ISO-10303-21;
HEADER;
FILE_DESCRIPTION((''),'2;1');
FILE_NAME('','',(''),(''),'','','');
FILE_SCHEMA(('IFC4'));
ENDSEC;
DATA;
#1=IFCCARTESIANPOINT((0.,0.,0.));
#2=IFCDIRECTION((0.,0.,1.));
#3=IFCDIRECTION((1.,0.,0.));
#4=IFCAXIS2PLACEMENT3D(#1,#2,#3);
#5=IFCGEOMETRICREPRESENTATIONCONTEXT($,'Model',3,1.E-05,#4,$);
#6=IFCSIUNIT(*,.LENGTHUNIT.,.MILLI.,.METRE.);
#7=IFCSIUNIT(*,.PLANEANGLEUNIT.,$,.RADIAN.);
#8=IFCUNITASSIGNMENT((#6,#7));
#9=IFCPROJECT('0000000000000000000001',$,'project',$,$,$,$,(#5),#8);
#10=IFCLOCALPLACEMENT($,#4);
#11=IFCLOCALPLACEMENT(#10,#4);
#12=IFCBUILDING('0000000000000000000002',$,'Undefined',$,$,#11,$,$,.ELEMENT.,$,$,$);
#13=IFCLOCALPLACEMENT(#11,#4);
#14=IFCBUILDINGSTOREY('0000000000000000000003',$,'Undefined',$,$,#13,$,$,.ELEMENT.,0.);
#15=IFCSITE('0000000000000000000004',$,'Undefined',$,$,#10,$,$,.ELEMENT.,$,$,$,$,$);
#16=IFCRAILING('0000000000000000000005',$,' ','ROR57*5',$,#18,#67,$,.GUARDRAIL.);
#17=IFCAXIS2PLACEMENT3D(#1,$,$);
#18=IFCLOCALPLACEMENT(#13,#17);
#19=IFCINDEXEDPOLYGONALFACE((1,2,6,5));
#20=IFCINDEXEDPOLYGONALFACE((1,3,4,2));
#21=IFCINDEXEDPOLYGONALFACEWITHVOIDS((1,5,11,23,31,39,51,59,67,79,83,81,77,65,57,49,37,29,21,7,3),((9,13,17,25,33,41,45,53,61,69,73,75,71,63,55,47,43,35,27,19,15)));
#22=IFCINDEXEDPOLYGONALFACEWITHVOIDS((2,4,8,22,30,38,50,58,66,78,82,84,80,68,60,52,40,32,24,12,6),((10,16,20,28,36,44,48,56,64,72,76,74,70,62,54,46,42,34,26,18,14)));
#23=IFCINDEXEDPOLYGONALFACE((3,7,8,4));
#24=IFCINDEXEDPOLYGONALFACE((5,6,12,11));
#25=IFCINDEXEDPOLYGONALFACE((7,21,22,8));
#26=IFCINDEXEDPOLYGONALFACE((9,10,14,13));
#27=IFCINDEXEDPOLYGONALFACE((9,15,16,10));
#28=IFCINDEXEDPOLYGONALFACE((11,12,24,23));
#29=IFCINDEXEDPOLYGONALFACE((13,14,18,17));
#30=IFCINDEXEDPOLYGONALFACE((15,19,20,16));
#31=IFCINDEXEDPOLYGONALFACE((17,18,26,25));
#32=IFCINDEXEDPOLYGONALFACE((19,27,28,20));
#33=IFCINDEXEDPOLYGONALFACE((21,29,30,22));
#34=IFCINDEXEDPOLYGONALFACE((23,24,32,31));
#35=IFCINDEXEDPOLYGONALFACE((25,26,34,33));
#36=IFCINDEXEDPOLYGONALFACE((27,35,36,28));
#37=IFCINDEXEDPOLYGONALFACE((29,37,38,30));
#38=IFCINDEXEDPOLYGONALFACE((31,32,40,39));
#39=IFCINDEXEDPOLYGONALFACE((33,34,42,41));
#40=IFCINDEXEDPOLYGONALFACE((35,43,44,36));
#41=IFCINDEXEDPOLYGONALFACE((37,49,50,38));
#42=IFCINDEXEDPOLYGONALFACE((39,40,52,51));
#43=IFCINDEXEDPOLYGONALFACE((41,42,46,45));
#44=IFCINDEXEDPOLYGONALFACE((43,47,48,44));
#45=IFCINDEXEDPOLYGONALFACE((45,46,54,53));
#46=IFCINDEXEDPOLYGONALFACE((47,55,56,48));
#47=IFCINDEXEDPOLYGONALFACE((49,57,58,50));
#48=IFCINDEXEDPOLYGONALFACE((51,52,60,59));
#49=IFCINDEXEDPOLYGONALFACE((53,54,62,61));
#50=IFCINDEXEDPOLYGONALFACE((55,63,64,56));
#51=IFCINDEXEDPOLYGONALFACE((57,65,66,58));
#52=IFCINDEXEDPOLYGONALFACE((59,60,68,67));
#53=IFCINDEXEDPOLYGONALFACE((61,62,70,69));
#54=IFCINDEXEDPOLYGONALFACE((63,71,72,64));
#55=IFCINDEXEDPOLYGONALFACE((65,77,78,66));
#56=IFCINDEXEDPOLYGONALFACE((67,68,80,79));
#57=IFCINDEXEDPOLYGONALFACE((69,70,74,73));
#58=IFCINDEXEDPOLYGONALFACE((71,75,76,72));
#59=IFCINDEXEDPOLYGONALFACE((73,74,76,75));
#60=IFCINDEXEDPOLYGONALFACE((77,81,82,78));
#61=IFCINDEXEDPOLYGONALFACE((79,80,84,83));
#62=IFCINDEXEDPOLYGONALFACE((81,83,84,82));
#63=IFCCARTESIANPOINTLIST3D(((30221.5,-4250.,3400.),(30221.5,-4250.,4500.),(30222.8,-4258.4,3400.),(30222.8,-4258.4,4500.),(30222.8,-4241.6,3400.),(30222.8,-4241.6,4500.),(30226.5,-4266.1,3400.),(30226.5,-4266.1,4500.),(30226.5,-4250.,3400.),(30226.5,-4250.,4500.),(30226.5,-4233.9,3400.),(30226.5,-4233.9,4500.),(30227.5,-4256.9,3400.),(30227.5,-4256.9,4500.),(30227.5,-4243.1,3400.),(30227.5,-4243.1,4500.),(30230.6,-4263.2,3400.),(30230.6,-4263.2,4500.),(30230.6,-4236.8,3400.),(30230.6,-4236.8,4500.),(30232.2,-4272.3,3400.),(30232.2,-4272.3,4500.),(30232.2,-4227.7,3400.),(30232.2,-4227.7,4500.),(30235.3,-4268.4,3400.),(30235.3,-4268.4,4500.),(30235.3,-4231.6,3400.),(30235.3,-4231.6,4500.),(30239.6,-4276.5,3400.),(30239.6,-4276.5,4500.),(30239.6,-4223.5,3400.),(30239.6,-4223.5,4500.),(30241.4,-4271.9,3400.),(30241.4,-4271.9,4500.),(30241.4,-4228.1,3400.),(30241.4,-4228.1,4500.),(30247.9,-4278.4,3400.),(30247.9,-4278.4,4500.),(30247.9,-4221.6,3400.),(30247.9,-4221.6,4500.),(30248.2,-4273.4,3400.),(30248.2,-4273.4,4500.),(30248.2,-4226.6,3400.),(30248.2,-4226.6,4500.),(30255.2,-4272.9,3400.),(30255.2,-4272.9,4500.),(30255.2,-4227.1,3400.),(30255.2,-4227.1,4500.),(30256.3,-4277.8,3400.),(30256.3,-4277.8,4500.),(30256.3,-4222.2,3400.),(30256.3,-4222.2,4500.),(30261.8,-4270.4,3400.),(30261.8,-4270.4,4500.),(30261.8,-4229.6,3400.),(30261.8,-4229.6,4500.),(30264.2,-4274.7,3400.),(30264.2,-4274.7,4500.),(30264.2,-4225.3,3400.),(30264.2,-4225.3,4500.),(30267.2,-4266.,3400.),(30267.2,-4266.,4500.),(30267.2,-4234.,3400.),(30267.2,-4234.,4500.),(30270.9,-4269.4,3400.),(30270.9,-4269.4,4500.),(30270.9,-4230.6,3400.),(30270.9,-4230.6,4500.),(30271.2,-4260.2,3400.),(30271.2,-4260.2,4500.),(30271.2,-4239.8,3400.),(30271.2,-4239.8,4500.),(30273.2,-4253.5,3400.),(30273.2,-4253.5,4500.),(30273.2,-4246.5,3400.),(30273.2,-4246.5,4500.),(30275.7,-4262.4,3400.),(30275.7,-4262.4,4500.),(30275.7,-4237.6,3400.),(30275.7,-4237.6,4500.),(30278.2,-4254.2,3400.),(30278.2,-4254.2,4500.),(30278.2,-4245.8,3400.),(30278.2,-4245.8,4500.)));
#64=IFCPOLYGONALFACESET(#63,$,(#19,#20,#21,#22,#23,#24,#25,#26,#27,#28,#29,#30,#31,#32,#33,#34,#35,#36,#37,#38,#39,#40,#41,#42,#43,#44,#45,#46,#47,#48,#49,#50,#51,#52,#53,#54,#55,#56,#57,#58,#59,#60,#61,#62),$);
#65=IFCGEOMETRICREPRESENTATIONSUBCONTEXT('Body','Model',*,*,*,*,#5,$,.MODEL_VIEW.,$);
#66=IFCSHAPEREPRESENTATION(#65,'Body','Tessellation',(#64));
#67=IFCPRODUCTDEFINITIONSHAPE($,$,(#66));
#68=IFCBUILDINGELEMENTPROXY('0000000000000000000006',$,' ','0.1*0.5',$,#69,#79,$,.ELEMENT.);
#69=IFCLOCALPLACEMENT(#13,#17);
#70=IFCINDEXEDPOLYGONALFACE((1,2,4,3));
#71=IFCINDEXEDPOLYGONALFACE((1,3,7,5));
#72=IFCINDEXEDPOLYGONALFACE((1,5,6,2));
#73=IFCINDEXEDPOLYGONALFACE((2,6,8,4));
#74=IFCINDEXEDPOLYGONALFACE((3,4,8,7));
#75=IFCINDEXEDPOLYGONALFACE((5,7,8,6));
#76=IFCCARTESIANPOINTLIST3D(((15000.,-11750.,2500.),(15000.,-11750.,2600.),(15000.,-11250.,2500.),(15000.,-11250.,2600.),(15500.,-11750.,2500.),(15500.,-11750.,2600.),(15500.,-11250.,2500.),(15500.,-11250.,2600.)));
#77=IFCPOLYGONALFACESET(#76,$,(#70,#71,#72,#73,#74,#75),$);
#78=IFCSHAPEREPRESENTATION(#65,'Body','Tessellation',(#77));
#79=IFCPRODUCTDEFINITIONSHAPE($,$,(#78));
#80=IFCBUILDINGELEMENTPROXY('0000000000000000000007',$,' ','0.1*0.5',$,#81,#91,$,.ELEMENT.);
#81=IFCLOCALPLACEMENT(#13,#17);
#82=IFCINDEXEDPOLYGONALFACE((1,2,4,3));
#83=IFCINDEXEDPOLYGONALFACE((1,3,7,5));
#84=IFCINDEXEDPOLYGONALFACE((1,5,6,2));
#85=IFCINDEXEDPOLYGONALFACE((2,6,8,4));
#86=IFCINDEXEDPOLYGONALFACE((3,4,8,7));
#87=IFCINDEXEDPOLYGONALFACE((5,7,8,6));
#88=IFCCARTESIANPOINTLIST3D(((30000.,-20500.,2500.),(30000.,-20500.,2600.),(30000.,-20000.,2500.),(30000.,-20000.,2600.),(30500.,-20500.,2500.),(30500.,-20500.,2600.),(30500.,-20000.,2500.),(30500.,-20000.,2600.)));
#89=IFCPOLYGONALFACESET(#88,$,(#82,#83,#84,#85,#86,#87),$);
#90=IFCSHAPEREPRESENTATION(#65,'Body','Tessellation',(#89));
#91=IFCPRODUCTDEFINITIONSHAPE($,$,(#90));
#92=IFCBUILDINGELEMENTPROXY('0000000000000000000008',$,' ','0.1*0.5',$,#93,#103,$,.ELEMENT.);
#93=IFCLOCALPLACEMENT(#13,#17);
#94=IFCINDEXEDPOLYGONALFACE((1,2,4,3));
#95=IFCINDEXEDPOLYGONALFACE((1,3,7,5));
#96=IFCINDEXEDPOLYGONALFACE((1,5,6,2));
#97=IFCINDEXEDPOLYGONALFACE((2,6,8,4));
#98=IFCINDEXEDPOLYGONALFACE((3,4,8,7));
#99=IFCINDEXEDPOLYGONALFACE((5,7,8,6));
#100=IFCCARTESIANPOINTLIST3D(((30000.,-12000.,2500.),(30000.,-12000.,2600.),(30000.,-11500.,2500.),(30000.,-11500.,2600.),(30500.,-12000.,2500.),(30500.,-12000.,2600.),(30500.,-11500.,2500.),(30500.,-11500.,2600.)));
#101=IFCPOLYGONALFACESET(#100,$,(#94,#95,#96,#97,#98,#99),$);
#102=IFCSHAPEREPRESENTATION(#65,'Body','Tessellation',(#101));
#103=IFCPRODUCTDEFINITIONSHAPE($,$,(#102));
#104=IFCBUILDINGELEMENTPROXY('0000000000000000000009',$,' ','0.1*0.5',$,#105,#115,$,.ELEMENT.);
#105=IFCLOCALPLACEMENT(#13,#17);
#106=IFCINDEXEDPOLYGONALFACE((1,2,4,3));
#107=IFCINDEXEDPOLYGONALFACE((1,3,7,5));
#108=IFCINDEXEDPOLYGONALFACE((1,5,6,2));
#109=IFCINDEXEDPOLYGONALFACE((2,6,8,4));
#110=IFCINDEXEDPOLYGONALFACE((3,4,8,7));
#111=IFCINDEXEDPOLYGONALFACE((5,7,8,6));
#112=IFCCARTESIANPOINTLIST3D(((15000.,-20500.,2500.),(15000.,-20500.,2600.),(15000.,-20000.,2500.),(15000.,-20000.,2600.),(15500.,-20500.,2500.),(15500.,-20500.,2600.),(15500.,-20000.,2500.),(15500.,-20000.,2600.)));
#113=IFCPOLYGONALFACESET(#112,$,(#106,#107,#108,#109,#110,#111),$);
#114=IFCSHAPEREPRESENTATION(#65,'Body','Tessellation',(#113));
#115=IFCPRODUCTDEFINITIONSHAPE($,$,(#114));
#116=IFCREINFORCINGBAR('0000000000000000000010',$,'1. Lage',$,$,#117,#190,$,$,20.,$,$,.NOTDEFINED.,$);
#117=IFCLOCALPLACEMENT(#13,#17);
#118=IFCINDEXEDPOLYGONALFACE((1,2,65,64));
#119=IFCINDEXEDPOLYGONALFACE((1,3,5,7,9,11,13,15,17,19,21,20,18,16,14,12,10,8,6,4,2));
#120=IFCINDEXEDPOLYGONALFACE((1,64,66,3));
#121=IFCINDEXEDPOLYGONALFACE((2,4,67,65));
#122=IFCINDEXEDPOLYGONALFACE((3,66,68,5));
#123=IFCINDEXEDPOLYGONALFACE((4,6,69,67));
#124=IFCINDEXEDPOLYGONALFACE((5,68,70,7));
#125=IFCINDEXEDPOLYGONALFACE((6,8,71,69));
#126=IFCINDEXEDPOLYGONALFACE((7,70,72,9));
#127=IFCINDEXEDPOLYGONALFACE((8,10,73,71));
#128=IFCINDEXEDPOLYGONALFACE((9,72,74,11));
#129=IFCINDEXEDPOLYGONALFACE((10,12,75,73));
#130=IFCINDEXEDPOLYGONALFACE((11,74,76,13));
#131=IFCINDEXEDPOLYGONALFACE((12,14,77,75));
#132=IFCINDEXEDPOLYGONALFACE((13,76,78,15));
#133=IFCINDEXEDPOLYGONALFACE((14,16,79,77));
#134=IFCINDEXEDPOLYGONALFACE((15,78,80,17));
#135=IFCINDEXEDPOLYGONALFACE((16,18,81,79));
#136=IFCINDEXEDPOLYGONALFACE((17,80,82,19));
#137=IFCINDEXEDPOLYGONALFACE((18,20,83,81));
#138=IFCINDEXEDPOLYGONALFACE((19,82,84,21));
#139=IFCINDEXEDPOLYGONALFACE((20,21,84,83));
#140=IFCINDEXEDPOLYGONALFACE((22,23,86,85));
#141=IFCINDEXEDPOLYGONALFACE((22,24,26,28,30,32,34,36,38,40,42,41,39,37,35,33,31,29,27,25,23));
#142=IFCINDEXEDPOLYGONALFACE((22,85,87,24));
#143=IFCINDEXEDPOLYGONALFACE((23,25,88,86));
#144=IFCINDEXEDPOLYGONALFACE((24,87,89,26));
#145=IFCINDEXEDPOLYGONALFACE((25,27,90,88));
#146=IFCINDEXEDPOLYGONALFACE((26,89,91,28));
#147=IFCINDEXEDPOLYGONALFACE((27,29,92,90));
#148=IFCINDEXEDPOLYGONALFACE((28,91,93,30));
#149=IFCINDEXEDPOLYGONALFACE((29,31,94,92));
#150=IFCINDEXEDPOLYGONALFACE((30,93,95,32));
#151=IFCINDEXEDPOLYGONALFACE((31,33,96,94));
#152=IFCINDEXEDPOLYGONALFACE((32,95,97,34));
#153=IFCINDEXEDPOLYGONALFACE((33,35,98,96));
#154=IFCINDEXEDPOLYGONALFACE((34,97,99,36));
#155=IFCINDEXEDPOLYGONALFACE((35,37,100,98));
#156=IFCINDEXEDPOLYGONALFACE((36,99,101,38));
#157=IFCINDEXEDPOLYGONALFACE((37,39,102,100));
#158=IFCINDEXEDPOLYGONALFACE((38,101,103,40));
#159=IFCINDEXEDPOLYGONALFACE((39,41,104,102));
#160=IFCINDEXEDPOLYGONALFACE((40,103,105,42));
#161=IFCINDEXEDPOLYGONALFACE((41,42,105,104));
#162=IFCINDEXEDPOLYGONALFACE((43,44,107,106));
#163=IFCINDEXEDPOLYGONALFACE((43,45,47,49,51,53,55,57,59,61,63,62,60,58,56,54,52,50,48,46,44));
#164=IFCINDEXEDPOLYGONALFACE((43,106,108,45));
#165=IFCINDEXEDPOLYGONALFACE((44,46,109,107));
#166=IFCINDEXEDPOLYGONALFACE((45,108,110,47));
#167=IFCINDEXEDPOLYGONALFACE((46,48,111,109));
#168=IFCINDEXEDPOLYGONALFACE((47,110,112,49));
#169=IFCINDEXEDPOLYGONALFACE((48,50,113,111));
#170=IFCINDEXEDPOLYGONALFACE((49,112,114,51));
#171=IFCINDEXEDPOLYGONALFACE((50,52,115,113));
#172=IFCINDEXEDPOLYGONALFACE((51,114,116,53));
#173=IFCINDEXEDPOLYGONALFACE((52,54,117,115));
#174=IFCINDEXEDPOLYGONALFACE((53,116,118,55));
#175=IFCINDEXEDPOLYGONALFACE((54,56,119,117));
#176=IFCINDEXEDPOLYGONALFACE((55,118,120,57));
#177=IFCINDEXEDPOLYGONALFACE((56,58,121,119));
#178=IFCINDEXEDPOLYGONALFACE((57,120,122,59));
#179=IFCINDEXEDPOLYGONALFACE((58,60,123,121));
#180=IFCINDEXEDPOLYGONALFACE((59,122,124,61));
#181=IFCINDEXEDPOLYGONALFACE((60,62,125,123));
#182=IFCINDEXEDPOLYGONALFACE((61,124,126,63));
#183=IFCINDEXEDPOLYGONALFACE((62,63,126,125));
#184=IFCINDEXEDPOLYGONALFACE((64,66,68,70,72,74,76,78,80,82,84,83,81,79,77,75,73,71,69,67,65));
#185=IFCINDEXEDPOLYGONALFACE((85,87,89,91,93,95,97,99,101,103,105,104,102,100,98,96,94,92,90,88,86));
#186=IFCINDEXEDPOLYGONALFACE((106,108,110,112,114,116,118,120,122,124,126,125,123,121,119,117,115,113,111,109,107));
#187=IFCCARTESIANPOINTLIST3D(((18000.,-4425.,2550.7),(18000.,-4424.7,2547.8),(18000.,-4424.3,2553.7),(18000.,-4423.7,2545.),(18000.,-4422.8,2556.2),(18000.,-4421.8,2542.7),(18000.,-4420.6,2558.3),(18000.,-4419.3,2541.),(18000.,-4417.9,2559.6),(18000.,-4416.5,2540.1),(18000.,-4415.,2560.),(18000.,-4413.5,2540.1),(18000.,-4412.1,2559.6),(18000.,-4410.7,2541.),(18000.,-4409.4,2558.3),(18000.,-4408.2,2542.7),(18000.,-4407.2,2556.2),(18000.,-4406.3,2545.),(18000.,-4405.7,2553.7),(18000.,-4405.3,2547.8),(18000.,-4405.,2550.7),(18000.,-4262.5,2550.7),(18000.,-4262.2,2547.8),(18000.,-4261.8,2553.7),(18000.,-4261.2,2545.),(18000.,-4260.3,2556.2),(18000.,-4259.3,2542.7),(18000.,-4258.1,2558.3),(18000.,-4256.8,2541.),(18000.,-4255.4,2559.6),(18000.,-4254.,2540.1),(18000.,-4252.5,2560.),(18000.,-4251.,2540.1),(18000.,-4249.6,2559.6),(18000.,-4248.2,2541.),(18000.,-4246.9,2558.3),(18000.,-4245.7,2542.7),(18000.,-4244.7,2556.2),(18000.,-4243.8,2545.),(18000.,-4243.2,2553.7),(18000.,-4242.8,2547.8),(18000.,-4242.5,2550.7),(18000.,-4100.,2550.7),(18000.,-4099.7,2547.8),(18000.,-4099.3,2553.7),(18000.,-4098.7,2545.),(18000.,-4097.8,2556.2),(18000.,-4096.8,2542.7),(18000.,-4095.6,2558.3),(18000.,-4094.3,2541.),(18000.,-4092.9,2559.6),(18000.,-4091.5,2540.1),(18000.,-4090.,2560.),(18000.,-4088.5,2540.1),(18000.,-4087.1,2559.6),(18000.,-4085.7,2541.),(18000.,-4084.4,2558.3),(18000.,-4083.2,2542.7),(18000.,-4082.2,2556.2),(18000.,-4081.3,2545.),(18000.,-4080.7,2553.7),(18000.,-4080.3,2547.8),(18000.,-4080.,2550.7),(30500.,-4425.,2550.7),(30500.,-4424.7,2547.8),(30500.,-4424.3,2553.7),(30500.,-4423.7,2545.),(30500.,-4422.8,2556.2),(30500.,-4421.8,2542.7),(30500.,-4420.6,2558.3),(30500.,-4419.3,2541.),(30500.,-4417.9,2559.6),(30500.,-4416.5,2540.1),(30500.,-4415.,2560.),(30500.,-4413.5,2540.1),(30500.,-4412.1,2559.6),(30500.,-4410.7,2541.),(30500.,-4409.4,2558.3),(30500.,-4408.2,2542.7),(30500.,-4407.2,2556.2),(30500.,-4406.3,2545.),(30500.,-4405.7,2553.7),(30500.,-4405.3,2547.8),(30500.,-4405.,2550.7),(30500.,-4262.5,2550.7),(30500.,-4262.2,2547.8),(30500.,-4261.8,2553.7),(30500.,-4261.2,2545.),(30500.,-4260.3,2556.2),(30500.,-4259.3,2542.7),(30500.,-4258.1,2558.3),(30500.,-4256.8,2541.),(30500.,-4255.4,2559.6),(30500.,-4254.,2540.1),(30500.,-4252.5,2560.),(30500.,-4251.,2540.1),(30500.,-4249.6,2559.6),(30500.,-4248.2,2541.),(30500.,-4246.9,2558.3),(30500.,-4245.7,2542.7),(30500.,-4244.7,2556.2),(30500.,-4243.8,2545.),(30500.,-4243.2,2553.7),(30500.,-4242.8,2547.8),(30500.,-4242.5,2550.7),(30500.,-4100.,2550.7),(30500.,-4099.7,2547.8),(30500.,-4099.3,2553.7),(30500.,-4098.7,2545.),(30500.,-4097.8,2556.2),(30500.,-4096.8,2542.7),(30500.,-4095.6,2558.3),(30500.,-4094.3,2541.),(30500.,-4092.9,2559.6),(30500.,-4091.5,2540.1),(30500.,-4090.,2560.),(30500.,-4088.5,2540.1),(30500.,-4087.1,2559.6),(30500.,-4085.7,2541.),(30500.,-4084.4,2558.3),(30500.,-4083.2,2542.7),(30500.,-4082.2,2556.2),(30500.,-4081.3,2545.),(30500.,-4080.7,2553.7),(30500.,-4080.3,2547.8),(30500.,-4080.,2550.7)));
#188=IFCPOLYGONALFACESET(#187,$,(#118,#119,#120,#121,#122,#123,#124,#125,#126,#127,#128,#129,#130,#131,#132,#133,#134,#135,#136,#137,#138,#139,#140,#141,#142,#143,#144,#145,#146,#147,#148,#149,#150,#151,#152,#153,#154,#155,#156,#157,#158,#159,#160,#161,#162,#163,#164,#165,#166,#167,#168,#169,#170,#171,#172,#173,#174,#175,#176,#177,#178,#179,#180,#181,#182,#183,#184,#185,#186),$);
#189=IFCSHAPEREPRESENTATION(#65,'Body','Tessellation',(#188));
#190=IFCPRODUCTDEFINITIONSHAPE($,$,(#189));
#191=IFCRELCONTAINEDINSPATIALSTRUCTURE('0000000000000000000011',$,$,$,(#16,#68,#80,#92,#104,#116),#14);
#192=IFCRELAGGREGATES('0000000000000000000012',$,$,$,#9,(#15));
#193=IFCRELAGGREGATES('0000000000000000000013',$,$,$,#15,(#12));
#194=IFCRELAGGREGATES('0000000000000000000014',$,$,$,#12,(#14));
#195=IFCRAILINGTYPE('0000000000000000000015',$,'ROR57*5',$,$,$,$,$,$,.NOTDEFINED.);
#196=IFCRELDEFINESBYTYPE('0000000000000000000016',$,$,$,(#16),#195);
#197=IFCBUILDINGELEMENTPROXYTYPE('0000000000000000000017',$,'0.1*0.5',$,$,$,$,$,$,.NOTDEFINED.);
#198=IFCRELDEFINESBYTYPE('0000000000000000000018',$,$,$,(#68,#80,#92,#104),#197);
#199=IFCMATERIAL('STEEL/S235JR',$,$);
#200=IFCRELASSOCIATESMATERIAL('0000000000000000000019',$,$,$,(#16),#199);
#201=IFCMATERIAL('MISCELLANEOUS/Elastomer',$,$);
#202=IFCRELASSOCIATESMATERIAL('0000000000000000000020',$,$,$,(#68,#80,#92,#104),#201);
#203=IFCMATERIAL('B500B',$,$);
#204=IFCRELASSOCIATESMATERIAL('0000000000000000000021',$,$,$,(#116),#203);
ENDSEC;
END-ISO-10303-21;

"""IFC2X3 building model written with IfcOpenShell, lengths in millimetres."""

from ifc_helpers import new_model, entity, si_unit, frame, origin_with_axes, origin_2d_with_axis, place, context, subcontext, project, spatial, polyline, hollow_circle, outline, extrude, source, transform, mapped, material, type_object, element, save


model = new_model("IFC2X3")

# Units and contexts
model_context = context("Model", 3, precision=1e-05, world=origin_with_axes())
body_context = subcontext(model_context, "Body", "Model", "MODEL_VIEW")
ifc_project = project(units=[si_unit("LENGTHUNIT", "METRE", prefix="MILLI"), si_unit("PLANEANGLEUNIT", "RADIAN")], contexts=[model_context])

# Site, building, storey
site_placement = place(None, origin_with_axes())
site = spatial("IfcSite", under=ifc_project, at=site_placement, Name="Undefined", CompositionType="ELEMENT")
building_placement = place(site_placement, origin_with_axes())
building = spatial("IfcBuilding", under=site, at=building_placement, Name="Undefined", CompositionType="ELEMENT")
storey_placement = place(building_placement, origin_with_axes())
storey = spatial("IfcBuildingStorey", under=building, at=storey_placement, Name="Undefined", CompositionType="ELEMENT", Elevation=0.0)

# Shared definitions
ifc_material_1 = material(Name="B500B")

# Railing
ifc_material_2 = material(Name="STEEL/S235JR")
railing_type = type_object("IfcRailingType", Name="ROR57*5", PredefinedType="NOTDEFINED")
for number, where, z_axis, x_axis, name in (
    (1, (30250.0, -4250.0, 3400.0), (0.0, 1.0, 0.0), (0.0, 0.0, 1.0), " "),
):
    element("IfcRailing", number, at=place(storey_placement, frame(where, z_axis=z_axis, x_axis=x_axis)), inside=storey, type_object=railing_type, material=ifc_material_2, Name=name, Description="ROR57*5", PredefinedType="GUARDRAIL", context=body_context, shape_type="SweptSolid", body=[
        extrude(hollow_circle(Radius=28.5, WallThickness=5.0, at=origin_2d_with_axis()), frame((1100.0, 0.0, 0.0), z_axis=(-1.0, 0.0, 0.0), x_axis=(0.0, -1.0, 0.0)), (0.0, 0.0, 1.0), 1100.0),
    ])

# Building element proxies
ifc_material_3 = material(Name="MISCELLANEOUS/Elastomer")
building_element_proxy_type = type_object("IfcBuildingElementProxyType", Name="0.1*0.5", PredefinedType="NOTDEFINED")
for number, where, z_axis, x_axis, name in (
    (2, (15000.0, -11750.0, 2550.0), (0.0, 0.0, 1.0), (1.0, 0.0, 0.0), " "),
    (3, (30000.0, -20500.0, 2550.0), (0.0, 0.0, 1.0), (1.0, 0.0, 0.0), " "),
    (4, (30000.0, -12000.0, 2550.0), (0.0, 0.0, 1.0), (1.0, 0.0, 0.0), " "),
    (5, (15000.0, -20500.0, 2550.0), (0.0, 0.0, 1.0), (1.0, 0.0, 0.0), " "),
):
    element("IfcBuildingElementProxy", number, at=place(storey_placement, frame(where, z_axis=z_axis, x_axis=x_axis)), inside=storey, type_object=building_element_proxy_type, material=ifc_material_3, Name=name, Description="0.1*0.5", CompositionType="ELEMENT", context=body_context, shape_type="SweptSolid", body=[
        extrude(outline(polyline([(0.0, 0.0), (500.0, 0.0), (500.0, 500.0), (0.0, 500.0), (0.0, 0.0)])), frame((0.0, 0.0, -50.0), z_axis=(0.0, 0.0, 1.0), x_axis=(1.0, 0.0, 0.0)), (0.0, 0.0, 1.0), 100.0),
    ])

# Reinforcing bar
shared_shape_1 = source(origin_with_axes(), body_context, "Body", "AdvancedSweptSolid", [
    entity("IfcSweptDiskSolid", entity("IfcTrimmedCurve", entity("IfcLine", entity("IfcCartesianPoint", [0.0, 0.0, 0.0]), entity("IfcVector", entity("IfcDirection", [1.0, 0.0, 0.0]), 1.0)), [entity("IfcParameterValue", 0.0)], [entity("IfcParameterValue", 12500.0)], True, "PARAMETER"), 10.0, None, 0.0, 12500.0),
])
shared_shape_2 = source(origin_with_axes(), body_context, "Body", "AdvancedSweptSolid", [
    entity("IfcSweptDiskSolid", entity("IfcTrimmedCurve", entity("IfcLine", entity("IfcCartesianPoint", [0.0, 0.0, 0.0]), entity("IfcVector", entity("IfcDirection", [1.0, 0.0, 0.0]), 1.0)), [entity("IfcParameterValue", 0.0)], [entity("IfcParameterValue", 12500.0)], True, "PARAMETER"), 10.0, None, 0.0, 12500.0),
])
shared_shape_3 = source(origin_with_axes(), body_context, "Body", "AdvancedSweptSolid", [
    entity("IfcSweptDiskSolid", entity("IfcTrimmedCurve", entity("IfcLine", entity("IfcCartesianPoint", [0.0, 0.0, 0.0]), entity("IfcVector", entity("IfcDirection", [1.0, 0.0, 0.0]), 1.0)), [entity("IfcParameterValue", 0.0)], [entity("IfcParameterValue", 12500.0)], True, "PARAMETER"), 10.0, None, 0.0, 12500.0),
])
reinforcing_bar_1_placement = place(storey_placement, frame((30500.0, -4415.0, 2550.0), z_axis=(0.0, 0.0, 1.0), x_axis=(-1.0, 0.0, 0.0)))
element("IfcReinforcingBar", 6, at=reinforcing_bar_1_placement, inside=storey, material=ifc_material_1, Name="1. Lage", BarRole="NOTDEFINED", NominalDiameter=20.0, context=body_context, shape_type="MappedRepresentation", body=[
    mapped(shared_shape_1, transform((0.0, 0.0, 0.0))),
    mapped(shared_shape_2, transform((0.0, -162.5, 0.0))),
    mapped(shared_shape_3, transform((0.0, -325.0, 0.0))),
])

save(model, "model.ifc")
